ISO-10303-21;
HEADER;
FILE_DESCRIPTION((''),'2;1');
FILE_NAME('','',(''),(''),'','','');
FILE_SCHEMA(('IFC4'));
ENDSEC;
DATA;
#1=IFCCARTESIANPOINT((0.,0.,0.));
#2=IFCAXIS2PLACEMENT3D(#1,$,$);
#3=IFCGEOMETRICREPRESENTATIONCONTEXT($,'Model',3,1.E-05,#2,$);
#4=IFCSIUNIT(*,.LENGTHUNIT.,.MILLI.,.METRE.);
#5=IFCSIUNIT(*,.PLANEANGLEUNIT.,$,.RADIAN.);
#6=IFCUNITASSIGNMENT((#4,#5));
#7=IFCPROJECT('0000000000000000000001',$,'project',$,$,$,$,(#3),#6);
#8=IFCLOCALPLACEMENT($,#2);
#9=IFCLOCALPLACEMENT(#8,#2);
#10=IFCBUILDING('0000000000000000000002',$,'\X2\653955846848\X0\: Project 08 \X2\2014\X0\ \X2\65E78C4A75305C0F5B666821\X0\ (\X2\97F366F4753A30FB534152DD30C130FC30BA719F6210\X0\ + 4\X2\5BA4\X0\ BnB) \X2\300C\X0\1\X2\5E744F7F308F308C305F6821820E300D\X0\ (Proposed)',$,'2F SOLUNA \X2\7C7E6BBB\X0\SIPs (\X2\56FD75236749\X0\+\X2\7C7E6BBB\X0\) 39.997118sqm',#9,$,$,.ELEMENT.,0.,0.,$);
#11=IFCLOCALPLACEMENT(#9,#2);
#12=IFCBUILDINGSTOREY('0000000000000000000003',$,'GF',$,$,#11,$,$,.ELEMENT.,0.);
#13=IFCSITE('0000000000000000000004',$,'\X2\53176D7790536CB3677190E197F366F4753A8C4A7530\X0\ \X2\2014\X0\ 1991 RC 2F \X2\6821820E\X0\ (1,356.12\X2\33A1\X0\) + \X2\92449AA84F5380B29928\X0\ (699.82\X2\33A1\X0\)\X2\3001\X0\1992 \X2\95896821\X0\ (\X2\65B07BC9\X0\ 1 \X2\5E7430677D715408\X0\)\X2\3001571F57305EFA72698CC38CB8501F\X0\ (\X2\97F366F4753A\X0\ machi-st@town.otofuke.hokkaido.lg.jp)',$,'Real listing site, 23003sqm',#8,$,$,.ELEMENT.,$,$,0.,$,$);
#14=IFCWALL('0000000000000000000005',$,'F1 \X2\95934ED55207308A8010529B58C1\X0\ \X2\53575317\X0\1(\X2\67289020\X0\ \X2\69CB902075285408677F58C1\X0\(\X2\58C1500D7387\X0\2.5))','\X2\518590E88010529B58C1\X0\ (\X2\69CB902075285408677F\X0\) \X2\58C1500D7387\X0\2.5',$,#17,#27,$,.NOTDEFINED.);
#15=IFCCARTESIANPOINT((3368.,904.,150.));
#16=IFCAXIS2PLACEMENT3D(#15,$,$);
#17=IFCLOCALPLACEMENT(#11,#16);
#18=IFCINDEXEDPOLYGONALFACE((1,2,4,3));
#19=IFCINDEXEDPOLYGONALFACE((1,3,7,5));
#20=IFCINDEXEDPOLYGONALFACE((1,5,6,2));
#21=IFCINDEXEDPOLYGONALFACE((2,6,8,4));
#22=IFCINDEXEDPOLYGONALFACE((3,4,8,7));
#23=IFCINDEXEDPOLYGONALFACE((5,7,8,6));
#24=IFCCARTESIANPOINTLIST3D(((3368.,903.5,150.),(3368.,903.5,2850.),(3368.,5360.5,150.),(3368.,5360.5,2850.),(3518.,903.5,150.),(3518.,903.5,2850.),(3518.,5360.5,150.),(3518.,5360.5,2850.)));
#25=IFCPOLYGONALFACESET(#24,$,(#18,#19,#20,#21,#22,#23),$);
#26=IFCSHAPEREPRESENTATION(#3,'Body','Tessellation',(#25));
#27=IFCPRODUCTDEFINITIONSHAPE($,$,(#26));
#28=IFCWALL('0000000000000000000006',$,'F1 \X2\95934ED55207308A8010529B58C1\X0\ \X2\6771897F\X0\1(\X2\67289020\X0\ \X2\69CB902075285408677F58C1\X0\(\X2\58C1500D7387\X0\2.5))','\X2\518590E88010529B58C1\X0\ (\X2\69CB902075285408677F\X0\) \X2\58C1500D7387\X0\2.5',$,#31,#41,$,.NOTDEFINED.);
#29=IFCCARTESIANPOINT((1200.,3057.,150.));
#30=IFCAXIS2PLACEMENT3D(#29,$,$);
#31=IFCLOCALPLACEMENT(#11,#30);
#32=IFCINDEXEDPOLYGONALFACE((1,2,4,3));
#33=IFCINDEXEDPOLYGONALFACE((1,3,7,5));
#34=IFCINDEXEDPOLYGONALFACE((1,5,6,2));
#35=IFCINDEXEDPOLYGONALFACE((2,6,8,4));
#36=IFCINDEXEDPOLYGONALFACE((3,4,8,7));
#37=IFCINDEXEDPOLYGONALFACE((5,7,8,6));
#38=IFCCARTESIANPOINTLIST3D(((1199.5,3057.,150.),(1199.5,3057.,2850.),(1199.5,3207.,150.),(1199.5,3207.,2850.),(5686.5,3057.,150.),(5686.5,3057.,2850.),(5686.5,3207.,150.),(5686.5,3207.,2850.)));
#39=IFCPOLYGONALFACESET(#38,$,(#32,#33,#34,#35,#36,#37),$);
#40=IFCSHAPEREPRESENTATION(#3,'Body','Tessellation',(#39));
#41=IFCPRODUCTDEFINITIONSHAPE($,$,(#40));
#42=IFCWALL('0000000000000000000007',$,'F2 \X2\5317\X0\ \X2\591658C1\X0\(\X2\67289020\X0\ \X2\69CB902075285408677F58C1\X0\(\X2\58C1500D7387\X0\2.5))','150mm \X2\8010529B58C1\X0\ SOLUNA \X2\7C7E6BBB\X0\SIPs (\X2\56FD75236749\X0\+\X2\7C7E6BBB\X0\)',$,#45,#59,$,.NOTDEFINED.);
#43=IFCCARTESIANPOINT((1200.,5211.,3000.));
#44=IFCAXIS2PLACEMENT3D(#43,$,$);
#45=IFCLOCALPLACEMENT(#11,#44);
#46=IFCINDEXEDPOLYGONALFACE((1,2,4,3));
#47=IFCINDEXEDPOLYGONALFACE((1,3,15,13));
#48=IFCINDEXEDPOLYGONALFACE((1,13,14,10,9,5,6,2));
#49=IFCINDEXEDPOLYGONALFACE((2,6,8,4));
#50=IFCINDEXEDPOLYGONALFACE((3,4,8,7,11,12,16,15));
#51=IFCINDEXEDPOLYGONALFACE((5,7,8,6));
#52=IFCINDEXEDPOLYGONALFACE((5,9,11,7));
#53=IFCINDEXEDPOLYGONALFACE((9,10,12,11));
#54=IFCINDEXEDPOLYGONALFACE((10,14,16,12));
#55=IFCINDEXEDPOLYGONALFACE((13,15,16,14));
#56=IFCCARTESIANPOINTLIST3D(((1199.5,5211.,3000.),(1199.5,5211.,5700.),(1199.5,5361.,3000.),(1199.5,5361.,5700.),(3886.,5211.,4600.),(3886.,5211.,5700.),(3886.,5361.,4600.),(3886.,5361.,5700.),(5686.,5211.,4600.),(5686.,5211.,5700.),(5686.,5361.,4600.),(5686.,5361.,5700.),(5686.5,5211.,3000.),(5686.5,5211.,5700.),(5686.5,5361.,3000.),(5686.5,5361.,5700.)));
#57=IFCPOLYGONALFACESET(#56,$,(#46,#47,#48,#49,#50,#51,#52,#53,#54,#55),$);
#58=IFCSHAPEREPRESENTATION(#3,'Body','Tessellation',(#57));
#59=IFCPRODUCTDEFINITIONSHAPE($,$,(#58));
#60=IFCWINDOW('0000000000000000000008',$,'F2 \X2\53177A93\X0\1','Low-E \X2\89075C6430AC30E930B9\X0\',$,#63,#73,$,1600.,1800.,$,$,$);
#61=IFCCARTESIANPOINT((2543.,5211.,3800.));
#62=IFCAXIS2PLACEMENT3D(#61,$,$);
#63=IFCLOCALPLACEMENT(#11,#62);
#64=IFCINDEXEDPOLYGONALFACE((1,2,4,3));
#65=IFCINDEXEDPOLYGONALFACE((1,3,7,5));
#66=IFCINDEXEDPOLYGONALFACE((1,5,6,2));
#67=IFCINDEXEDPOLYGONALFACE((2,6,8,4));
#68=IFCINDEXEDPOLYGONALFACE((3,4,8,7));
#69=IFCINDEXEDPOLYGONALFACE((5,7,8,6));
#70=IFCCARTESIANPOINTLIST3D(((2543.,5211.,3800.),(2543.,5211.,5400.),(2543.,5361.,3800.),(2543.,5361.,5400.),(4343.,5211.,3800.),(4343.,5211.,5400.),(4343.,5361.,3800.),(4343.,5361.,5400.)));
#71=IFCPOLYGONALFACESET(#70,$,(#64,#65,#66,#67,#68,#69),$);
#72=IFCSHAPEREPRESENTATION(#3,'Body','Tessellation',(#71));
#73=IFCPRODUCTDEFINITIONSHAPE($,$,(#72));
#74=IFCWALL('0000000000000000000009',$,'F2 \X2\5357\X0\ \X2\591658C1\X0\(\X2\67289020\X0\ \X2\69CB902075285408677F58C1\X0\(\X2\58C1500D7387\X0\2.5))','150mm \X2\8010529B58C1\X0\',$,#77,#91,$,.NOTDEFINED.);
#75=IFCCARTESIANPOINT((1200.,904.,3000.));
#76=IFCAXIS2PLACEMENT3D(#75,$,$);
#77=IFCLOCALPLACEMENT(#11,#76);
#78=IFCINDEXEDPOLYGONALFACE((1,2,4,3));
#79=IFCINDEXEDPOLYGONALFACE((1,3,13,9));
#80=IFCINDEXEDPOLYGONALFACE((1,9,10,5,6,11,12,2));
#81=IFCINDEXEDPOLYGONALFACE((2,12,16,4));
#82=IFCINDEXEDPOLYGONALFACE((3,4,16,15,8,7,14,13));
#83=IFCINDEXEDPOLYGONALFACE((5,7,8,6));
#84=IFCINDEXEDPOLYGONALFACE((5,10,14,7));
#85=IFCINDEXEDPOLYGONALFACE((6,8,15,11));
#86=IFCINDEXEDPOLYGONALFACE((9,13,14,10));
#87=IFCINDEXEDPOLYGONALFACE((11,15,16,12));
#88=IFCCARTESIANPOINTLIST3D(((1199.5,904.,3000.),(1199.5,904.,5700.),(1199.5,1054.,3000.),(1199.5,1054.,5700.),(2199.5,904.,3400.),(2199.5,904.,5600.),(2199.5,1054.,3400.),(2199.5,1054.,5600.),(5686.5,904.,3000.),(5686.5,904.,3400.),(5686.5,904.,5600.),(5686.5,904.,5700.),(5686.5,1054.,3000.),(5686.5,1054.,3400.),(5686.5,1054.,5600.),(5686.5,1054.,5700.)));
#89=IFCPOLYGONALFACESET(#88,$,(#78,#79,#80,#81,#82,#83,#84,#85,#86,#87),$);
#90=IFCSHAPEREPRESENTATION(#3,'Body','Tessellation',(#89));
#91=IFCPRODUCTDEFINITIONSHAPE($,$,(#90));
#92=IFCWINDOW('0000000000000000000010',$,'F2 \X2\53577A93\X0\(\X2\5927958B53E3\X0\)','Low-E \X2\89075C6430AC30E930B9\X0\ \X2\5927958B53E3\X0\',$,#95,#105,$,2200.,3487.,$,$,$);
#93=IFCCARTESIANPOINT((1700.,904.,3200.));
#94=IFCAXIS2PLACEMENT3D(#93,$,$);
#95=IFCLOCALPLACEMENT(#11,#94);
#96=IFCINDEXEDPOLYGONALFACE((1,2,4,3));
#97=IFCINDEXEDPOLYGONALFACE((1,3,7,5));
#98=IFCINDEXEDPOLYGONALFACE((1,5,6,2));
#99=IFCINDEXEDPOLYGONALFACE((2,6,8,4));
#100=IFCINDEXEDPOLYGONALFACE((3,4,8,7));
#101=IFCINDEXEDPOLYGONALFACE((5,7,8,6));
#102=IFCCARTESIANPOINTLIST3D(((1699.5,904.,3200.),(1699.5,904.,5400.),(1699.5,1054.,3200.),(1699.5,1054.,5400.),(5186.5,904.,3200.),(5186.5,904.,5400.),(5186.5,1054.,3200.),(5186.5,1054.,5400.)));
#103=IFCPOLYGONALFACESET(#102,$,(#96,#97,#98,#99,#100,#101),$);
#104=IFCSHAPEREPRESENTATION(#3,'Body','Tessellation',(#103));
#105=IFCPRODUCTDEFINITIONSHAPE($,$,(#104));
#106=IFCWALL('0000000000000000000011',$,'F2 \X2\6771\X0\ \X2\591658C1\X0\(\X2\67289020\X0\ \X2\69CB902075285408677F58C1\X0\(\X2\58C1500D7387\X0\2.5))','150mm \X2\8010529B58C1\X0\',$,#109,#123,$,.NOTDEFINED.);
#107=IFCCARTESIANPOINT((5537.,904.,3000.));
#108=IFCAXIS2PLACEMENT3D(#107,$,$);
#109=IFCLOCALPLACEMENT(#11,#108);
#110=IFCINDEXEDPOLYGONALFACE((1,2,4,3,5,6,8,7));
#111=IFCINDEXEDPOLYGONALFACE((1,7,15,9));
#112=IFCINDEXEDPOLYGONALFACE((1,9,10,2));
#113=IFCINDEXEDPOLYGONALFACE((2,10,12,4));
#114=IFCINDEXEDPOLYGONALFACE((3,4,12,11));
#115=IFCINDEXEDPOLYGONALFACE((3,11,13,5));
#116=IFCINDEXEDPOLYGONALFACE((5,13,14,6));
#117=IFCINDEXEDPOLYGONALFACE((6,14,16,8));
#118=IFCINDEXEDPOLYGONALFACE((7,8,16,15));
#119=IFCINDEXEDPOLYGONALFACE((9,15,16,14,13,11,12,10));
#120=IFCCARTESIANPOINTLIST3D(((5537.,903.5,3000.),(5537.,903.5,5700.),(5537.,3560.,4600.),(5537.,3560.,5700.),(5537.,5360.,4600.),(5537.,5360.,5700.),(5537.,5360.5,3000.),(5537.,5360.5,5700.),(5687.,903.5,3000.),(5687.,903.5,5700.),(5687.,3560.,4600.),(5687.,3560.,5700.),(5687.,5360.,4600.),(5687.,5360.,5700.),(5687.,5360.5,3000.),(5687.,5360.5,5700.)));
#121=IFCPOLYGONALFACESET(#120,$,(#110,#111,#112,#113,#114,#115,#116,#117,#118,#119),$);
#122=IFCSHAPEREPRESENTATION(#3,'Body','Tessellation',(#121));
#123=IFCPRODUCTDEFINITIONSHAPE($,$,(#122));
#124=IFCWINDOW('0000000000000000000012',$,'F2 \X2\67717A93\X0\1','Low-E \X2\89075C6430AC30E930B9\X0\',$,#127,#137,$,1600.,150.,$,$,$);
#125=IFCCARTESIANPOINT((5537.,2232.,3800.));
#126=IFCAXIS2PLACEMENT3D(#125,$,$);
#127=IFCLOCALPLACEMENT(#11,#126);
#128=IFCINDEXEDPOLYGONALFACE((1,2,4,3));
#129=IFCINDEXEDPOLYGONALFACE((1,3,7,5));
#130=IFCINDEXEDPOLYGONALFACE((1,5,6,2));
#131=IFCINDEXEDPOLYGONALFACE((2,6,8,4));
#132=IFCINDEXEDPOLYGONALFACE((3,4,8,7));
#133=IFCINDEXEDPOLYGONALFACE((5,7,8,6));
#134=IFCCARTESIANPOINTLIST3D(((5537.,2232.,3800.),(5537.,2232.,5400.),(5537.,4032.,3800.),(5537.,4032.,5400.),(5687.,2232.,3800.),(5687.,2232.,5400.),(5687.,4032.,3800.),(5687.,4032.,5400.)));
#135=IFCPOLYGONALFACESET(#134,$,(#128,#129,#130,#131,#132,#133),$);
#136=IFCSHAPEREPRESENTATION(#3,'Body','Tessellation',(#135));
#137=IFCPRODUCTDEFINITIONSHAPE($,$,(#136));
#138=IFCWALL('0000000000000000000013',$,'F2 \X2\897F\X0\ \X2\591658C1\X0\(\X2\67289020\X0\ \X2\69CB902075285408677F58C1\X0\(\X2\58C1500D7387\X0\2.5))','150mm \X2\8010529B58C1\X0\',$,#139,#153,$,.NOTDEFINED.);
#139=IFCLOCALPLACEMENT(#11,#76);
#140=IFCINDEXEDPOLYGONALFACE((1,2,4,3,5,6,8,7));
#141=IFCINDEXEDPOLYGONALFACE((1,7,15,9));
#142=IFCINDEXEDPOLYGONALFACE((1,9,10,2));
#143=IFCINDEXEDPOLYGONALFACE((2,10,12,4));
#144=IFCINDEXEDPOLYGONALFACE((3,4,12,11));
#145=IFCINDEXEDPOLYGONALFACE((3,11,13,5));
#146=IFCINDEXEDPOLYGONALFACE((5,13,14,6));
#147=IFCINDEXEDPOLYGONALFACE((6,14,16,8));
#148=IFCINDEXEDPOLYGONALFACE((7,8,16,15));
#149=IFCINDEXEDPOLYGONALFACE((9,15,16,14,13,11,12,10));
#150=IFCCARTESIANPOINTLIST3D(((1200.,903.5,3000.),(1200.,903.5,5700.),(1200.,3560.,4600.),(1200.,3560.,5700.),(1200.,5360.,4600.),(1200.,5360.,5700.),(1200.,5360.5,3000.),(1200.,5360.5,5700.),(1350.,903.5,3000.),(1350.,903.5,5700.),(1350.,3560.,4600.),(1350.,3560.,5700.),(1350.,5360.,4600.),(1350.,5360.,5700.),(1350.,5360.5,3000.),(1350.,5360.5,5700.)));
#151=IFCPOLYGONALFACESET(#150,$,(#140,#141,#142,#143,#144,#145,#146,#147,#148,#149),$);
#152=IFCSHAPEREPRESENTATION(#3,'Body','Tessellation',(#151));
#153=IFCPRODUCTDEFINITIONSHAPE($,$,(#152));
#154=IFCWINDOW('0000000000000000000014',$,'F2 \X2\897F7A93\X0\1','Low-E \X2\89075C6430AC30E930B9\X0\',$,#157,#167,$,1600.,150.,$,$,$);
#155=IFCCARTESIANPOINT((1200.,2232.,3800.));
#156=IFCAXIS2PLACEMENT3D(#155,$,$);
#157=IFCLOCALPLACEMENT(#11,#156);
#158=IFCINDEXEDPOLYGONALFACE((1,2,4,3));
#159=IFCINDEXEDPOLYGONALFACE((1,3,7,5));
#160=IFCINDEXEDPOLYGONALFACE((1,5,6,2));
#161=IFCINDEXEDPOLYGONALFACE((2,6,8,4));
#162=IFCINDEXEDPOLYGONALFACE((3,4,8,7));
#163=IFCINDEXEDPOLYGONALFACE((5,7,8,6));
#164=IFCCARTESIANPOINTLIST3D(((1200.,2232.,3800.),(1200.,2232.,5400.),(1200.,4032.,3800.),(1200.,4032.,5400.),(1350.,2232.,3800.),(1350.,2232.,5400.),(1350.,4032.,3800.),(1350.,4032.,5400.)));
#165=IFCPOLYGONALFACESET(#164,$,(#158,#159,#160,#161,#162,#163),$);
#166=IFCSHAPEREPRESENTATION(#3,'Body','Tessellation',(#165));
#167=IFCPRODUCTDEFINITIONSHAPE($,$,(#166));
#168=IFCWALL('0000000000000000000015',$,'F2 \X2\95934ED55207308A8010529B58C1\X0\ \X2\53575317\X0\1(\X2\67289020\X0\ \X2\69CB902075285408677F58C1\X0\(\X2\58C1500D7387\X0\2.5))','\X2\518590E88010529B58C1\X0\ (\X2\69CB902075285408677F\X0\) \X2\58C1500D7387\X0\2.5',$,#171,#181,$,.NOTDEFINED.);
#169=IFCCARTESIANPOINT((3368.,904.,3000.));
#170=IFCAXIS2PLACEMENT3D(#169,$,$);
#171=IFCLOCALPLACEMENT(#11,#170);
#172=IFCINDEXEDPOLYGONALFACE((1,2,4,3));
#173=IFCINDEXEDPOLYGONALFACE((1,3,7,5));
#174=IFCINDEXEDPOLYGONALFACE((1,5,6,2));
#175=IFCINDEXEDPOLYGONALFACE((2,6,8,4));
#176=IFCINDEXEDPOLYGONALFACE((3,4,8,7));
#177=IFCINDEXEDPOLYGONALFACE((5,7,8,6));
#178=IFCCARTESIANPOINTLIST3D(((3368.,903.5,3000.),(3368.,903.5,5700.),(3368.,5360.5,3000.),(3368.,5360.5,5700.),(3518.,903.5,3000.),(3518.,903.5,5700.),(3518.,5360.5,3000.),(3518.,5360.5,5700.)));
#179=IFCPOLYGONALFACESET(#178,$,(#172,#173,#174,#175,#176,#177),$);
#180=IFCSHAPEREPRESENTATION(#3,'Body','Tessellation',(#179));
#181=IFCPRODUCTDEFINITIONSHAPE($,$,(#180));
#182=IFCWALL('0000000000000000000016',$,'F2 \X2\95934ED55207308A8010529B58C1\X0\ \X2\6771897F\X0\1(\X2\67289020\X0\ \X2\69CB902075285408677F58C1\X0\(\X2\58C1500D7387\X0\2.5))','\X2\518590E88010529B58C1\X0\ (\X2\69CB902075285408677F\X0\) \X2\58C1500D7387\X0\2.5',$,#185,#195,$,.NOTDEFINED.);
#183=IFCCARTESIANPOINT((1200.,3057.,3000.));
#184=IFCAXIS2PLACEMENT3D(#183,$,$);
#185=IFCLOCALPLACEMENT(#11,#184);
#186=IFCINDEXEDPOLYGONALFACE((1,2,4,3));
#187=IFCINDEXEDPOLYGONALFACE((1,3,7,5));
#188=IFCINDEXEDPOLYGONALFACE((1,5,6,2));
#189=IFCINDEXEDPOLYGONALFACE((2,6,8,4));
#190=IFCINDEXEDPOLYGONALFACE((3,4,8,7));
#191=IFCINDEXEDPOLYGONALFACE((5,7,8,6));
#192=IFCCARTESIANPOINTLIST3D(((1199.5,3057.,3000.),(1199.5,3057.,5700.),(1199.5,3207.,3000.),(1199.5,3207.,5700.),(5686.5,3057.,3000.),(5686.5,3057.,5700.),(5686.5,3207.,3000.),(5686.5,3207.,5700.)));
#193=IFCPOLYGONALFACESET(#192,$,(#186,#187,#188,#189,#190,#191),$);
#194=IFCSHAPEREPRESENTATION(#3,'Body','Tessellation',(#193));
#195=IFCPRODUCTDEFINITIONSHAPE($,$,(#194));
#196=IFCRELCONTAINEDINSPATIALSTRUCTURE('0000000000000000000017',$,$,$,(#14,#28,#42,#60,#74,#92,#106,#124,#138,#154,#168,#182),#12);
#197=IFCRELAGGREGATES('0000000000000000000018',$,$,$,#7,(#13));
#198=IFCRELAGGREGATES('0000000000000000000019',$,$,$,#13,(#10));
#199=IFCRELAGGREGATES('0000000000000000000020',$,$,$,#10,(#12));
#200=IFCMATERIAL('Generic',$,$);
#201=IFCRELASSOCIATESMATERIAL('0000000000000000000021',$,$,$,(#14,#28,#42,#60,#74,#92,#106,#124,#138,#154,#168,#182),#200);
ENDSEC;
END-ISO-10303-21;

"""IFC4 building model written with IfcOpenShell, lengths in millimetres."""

from ifc_helpers import new_model, si_unit, frame, frame_2d, origin, place, context, project, spatial, rectangle, extrude, material, element, fill, save


model = new_model("IFC4")

# Units and contexts
model_context = context("Model", 3, precision=1e-05, world=origin())
ifc_project = project(units=[si_unit("LENGTHUNIT", "METRE", prefix="MILLI"), si_unit("PLANEANGLEUNIT", "RADIAN")], contexts=[model_context])

# Site, building, storey
site_placement = place(None, origin())
site = spatial("IfcSite", under=ifc_project, at=site_placement, Name="北海道河東郡音更町豊田 — 1991 RC 2F 校舎 (1,356.12㎡) + 鉄骨体育館 (699.82㎡)、1992 閉校 (新築 1 年で統合)、土地建物賃貸借 (音更町 machi-st@town.otofuke.hokkaido.lg.jp)", ObjectType="Real listing site, 23003sqm", CompositionType="ELEMENT", RefElevation=0.0)
building_placement = place(site_placement, origin())
building = spatial("IfcBuilding", under=site, at=building_placement, Name="改善案: Project 08 — 旧豊田小学校 (音更町・十勝チーズ熟成 + 4室 BnB) 「1年使われた校舎」 (Proposed)", ObjectType="2F SOLUNA 籾殻SIPs (国産杉+籾殻) 39.997118sqm", CompositionType="ELEMENT", ElevationOfRefHeight=0.0, ElevationOfTerrain=0.0)
storey_placement = place(building_placement, origin())
storey = spatial("IfcBuildingStorey", under=building, at=storey_placement, Name="GF", CompositionType="ELEMENT", Elevation=0.0)

# Shared definitions
ifc_material_1 = material(Name="Generic")

# Walls
wall_1_placement = place(storey_placement, frame((3368.0, 904.0, 150.0)))
element("IfcWall", 1, at=wall_1_placement, inside=storey, material=ifc_material_1, Name="F1 間仕切り耐力壁 南北1(木造 構造用合板壁(壁倍率2.5))", Description="内部耐力壁 (構造用合板) 壁倍率2.5", PredefinedType="NOTDEFINED", context=model_context, shape_type="SweptSolid", body=[
    extrude(rectangle(XDim=150.0, YDim=4457.0, at=frame_2d((75.0, 2228.0))), frame((3368.0, 904.0, 150.0)), (0.0, 0.0, 1.0), 2700.0),
])
wall_2_placement = place(storey_placement, frame((1200.0, 3057.0, 150.0)))
element("IfcWall", 2, at=wall_2_placement, inside=storey, material=ifc_material_1, Name="F1 間仕切り耐力壁 東西1(木造 構造用合板壁(壁倍率2.5))", Description="内部耐力壁 (構造用合板) 壁倍率2.5", PredefinedType="NOTDEFINED", context=model_context, shape_type="SweptSolid", body=[
    extrude(rectangle(XDim=4487.0, YDim=150.0, at=frame_2d((2243.0, 75.0))), frame((1200.0, 3057.0, 150.0)), (0.0, 0.0, 1.0), 2700.0),
])

# Walls, openings, windows
wall_3_placement = place(storey_placement, frame((1200.0, 5211.0, 3000.0)))
wall_3 = element("IfcWall", 3, at=wall_3_placement, inside=storey, material=ifc_material_1, Name="F2 北 外壁(木造 構造用合板壁(壁倍率2.5))", Description="150mm 耐力壁 SOLUNA 籾殻SIPs (国産杉+籾殻)", PredefinedType="NOTDEFINED", context=model_context, shape_type="SweptSolid", body=[
    extrude(rectangle(XDim=4487.0, YDim=150.0, at=frame_2d((2243.0, 75.0))), frame((1200.0, 5211.0, 3000.0)), (0.0, 0.0, 1.0), 2700.0),
])
opening_1_placement = place(storey_placement, frame((2543.0, 5211.0, 3800.0)))
opening_1 = element("IfcOpeningElement", 4, at=opening_1_placement, cuts=wall_3, PredefinedType="NOTDEFINED", context=model_context, shape_type="SweptSolid", body=[
    extrude(rectangle(XDim=1800.0, YDim=150.0, at=frame_2d((900.0, 75.0))), frame((2543.0, 5211.0, 3800.0)), (0.0, 0.0, 1.0), 1600.0),
])
window_1_placement = place(storey_placement, frame((2543.0, 5211.0, 3800.0)))
window_1 = element("IfcWindow", 5, at=window_1_placement, inside=storey, material=ifc_material_1, Name="F2 北窓1", Description="Low-E 複層ガラス", OverallHeight=1600.0, OverallWidth=1800.0, context=model_context, shape_type="SweptSolid", body=[
    extrude(rectangle(XDim=1800.0, YDim=150.0, at=frame_2d((900.0, 75.0))), frame((2543.0, 5211.0, 3800.0)), (0.0, 0.0, 1.0), 1600.0),
])
fill(opening_1, window_1)
wall_4_placement = place(storey_placement, frame((1200.0, 904.0, 3000.0)))
wall_4 = element("IfcWall", 6, at=wall_4_placement, inside=storey, material=ifc_material_1, Name="F2 南 外壁(木造 構造用合板壁(壁倍率2.5))", Description="150mm 耐力壁", PredefinedType="NOTDEFINED", context=model_context, shape_type="SweptSolid", body=[
    extrude(rectangle(XDim=4487.0, YDim=150.0, at=frame_2d((2243.0, 75.0))), frame((1200.0, 904.0, 3000.0)), (0.0, 0.0, 1.0), 2700.0),
])
opening_2_placement = place(storey_placement, frame((1700.0, 904.0, 3200.0)))
opening_2 = element("IfcOpeningElement", 7, at=opening_2_placement, cuts=wall_4, PredefinedType="NOTDEFINED", context=model_context, shape_type="SweptSolid", body=[
    extrude(rectangle(XDim=3487.0, YDim=150.0, at=frame_2d((1743.0, 75.0))), frame((1700.0, 904.0, 3200.0)), (0.0, 0.0, 1.0), 2200.0),
])
window_2_placement = place(storey_placement, frame((1700.0, 904.0, 3200.0)))
window_2 = element("IfcWindow", 8, at=window_2_placement, inside=storey, material=ifc_material_1, Name="F2 南窓(大開口)", Description="Low-E 複層ガラス 大開口", OverallHeight=2200.0, OverallWidth=3487.0, context=model_context, shape_type="SweptSolid", body=[
    extrude(rectangle(XDim=3487.0, YDim=150.0, at=frame_2d((1743.0, 75.0))), frame((1700.0, 904.0, 3200.0)), (0.0, 0.0, 1.0), 2200.0),
])
fill(opening_2, window_2)
wall_5_placement = place(storey_placement, frame((5537.0, 904.0, 3000.0)))
wall_5 = element("IfcWall", 9, at=wall_5_placement, inside=storey, material=ifc_material_1, Name="F2 東 外壁(木造 構造用合板壁(壁倍率2.5))", Description="150mm 耐力壁", PredefinedType="NOTDEFINED", context=model_context, shape_type="SweptSolid", body=[
    extrude(rectangle(XDim=150.0, YDim=4457.0, at=frame_2d((75.0, 2228.0))), frame((5537.0, 904.0, 3000.0)), (0.0, 0.0, 1.0), 2700.0),
])
opening_3_placement = place(storey_placement, frame((5537.0, 2232.0, 3800.0)))
opening_3 = element("IfcOpeningElement", 10, at=opening_3_placement, cuts=wall_5, PredefinedType="NOTDEFINED", context=model_context, shape_type="SweptSolid", body=[
    extrude(rectangle(XDim=150.0, YDim=1800.0, at=frame_2d((75.0, 900.0))), frame((5537.0, 2232.0, 3800.0)), (0.0, 0.0, 1.0), 1600.0),
])
window_3_placement = place(storey_placement, frame((5537.0, 2232.0, 3800.0)))
window_3 = element("IfcWindow", 11, at=window_3_placement, inside=storey, material=ifc_material_1, Name="F2 東窓1", Description="Low-E 複層ガラス", OverallHeight=1600.0, OverallWidth=150.0, context=model_context, shape_type="SweptSolid", body=[
    extrude(rectangle(XDim=150.0, YDim=1800.0, at=frame_2d((75.0, 900.0))), frame((5537.0, 2232.0, 3800.0)), (0.0, 0.0, 1.0), 1600.0),
])
fill(opening_3, window_3)
wall_6_placement = place(storey_placement, frame((1200.0, 904.0, 3000.0)))
wall_6 = element("IfcWall", 12, at=wall_6_placement, inside=storey, material=ifc_material_1, Name="F2 西 外壁(木造 構造用合板壁(壁倍率2.5))", Description="150mm 耐力壁", PredefinedType="NOTDEFINED", context=model_context, shape_type="SweptSolid", body=[
    extrude(rectangle(XDim=150.0, YDim=4457.0, at=frame_2d((75.0, 2228.0))), frame((1200.0, 904.0, 3000.0)), (0.0, 0.0, 1.0), 2700.0),
])
opening_4_placement = place(storey_placement, frame((1200.0, 2232.0, 3800.0)))
opening_4 = element("IfcOpeningElement", 13, at=opening_4_placement, cuts=wall_6, PredefinedType="NOTDEFINED", context=model_context, shape_type="SweptSolid", body=[
    extrude(rectangle(XDim=150.0, YDim=1800.0, at=frame_2d((75.0, 900.0))), frame((1200.0, 2232.0, 3800.0)), (0.0, 0.0, 1.0), 1600.0),
])
window_4_placement = place(storey_placement, frame((1200.0, 2232.0, 3800.0)))
window_4 = element("IfcWindow", 14, at=window_4_placement, inside=storey, material=ifc_material_1, Name="F2 西窓1", Description="Low-E 複層ガラス", OverallHeight=1600.0, OverallWidth=150.0, context=model_context, shape_type="SweptSolid", body=[
    extrude(rectangle(XDim=150.0, YDim=1800.0, at=frame_2d((75.0, 900.0))), frame((1200.0, 2232.0, 3800.0)), (0.0, 0.0, 1.0), 1600.0),
])
fill(opening_4, window_4)

# Walls
wall_7_placement = place(storey_placement, frame((3368.0, 904.0, 3000.0)))
element("IfcWall", 15, at=wall_7_placement, inside=storey, material=ifc_material_1, Name="F2 間仕切り耐力壁 南北1(木造 構造用合板壁(壁倍率2.5))", Description="内部耐力壁 (構造用合板) 壁倍率2.5", PredefinedType="NOTDEFINED", context=model_context, shape_type="SweptSolid", body=[
    extrude(rectangle(XDim=150.0, YDim=4457.0, at=frame_2d((75.0, 2228.0))), frame((3368.0, 904.0, 3000.0)), (0.0, 0.0, 1.0), 2700.0),
])
wall_8_placement = place(storey_placement, frame((1200.0, 3057.0, 3000.0)))
element("IfcWall", 16, at=wall_8_placement, inside=storey, material=ifc_material_1, Name="F2 間仕切り耐力壁 東西1(木造 構造用合板壁(壁倍率2.5))", Description="内部耐力壁 (構造用合板) 壁倍率2.5", PredefinedType="NOTDEFINED", context=model_context, shape_type="SweptSolid", body=[
    extrude(rectangle(XDim=4487.0, YDim=150.0, at=frame_2d((2243.0, 75.0))), frame((1200.0, 3057.0, 3000.0)), (0.0, 0.0, 1.0), 2700.0),
])

save(model, "model.ifc")
